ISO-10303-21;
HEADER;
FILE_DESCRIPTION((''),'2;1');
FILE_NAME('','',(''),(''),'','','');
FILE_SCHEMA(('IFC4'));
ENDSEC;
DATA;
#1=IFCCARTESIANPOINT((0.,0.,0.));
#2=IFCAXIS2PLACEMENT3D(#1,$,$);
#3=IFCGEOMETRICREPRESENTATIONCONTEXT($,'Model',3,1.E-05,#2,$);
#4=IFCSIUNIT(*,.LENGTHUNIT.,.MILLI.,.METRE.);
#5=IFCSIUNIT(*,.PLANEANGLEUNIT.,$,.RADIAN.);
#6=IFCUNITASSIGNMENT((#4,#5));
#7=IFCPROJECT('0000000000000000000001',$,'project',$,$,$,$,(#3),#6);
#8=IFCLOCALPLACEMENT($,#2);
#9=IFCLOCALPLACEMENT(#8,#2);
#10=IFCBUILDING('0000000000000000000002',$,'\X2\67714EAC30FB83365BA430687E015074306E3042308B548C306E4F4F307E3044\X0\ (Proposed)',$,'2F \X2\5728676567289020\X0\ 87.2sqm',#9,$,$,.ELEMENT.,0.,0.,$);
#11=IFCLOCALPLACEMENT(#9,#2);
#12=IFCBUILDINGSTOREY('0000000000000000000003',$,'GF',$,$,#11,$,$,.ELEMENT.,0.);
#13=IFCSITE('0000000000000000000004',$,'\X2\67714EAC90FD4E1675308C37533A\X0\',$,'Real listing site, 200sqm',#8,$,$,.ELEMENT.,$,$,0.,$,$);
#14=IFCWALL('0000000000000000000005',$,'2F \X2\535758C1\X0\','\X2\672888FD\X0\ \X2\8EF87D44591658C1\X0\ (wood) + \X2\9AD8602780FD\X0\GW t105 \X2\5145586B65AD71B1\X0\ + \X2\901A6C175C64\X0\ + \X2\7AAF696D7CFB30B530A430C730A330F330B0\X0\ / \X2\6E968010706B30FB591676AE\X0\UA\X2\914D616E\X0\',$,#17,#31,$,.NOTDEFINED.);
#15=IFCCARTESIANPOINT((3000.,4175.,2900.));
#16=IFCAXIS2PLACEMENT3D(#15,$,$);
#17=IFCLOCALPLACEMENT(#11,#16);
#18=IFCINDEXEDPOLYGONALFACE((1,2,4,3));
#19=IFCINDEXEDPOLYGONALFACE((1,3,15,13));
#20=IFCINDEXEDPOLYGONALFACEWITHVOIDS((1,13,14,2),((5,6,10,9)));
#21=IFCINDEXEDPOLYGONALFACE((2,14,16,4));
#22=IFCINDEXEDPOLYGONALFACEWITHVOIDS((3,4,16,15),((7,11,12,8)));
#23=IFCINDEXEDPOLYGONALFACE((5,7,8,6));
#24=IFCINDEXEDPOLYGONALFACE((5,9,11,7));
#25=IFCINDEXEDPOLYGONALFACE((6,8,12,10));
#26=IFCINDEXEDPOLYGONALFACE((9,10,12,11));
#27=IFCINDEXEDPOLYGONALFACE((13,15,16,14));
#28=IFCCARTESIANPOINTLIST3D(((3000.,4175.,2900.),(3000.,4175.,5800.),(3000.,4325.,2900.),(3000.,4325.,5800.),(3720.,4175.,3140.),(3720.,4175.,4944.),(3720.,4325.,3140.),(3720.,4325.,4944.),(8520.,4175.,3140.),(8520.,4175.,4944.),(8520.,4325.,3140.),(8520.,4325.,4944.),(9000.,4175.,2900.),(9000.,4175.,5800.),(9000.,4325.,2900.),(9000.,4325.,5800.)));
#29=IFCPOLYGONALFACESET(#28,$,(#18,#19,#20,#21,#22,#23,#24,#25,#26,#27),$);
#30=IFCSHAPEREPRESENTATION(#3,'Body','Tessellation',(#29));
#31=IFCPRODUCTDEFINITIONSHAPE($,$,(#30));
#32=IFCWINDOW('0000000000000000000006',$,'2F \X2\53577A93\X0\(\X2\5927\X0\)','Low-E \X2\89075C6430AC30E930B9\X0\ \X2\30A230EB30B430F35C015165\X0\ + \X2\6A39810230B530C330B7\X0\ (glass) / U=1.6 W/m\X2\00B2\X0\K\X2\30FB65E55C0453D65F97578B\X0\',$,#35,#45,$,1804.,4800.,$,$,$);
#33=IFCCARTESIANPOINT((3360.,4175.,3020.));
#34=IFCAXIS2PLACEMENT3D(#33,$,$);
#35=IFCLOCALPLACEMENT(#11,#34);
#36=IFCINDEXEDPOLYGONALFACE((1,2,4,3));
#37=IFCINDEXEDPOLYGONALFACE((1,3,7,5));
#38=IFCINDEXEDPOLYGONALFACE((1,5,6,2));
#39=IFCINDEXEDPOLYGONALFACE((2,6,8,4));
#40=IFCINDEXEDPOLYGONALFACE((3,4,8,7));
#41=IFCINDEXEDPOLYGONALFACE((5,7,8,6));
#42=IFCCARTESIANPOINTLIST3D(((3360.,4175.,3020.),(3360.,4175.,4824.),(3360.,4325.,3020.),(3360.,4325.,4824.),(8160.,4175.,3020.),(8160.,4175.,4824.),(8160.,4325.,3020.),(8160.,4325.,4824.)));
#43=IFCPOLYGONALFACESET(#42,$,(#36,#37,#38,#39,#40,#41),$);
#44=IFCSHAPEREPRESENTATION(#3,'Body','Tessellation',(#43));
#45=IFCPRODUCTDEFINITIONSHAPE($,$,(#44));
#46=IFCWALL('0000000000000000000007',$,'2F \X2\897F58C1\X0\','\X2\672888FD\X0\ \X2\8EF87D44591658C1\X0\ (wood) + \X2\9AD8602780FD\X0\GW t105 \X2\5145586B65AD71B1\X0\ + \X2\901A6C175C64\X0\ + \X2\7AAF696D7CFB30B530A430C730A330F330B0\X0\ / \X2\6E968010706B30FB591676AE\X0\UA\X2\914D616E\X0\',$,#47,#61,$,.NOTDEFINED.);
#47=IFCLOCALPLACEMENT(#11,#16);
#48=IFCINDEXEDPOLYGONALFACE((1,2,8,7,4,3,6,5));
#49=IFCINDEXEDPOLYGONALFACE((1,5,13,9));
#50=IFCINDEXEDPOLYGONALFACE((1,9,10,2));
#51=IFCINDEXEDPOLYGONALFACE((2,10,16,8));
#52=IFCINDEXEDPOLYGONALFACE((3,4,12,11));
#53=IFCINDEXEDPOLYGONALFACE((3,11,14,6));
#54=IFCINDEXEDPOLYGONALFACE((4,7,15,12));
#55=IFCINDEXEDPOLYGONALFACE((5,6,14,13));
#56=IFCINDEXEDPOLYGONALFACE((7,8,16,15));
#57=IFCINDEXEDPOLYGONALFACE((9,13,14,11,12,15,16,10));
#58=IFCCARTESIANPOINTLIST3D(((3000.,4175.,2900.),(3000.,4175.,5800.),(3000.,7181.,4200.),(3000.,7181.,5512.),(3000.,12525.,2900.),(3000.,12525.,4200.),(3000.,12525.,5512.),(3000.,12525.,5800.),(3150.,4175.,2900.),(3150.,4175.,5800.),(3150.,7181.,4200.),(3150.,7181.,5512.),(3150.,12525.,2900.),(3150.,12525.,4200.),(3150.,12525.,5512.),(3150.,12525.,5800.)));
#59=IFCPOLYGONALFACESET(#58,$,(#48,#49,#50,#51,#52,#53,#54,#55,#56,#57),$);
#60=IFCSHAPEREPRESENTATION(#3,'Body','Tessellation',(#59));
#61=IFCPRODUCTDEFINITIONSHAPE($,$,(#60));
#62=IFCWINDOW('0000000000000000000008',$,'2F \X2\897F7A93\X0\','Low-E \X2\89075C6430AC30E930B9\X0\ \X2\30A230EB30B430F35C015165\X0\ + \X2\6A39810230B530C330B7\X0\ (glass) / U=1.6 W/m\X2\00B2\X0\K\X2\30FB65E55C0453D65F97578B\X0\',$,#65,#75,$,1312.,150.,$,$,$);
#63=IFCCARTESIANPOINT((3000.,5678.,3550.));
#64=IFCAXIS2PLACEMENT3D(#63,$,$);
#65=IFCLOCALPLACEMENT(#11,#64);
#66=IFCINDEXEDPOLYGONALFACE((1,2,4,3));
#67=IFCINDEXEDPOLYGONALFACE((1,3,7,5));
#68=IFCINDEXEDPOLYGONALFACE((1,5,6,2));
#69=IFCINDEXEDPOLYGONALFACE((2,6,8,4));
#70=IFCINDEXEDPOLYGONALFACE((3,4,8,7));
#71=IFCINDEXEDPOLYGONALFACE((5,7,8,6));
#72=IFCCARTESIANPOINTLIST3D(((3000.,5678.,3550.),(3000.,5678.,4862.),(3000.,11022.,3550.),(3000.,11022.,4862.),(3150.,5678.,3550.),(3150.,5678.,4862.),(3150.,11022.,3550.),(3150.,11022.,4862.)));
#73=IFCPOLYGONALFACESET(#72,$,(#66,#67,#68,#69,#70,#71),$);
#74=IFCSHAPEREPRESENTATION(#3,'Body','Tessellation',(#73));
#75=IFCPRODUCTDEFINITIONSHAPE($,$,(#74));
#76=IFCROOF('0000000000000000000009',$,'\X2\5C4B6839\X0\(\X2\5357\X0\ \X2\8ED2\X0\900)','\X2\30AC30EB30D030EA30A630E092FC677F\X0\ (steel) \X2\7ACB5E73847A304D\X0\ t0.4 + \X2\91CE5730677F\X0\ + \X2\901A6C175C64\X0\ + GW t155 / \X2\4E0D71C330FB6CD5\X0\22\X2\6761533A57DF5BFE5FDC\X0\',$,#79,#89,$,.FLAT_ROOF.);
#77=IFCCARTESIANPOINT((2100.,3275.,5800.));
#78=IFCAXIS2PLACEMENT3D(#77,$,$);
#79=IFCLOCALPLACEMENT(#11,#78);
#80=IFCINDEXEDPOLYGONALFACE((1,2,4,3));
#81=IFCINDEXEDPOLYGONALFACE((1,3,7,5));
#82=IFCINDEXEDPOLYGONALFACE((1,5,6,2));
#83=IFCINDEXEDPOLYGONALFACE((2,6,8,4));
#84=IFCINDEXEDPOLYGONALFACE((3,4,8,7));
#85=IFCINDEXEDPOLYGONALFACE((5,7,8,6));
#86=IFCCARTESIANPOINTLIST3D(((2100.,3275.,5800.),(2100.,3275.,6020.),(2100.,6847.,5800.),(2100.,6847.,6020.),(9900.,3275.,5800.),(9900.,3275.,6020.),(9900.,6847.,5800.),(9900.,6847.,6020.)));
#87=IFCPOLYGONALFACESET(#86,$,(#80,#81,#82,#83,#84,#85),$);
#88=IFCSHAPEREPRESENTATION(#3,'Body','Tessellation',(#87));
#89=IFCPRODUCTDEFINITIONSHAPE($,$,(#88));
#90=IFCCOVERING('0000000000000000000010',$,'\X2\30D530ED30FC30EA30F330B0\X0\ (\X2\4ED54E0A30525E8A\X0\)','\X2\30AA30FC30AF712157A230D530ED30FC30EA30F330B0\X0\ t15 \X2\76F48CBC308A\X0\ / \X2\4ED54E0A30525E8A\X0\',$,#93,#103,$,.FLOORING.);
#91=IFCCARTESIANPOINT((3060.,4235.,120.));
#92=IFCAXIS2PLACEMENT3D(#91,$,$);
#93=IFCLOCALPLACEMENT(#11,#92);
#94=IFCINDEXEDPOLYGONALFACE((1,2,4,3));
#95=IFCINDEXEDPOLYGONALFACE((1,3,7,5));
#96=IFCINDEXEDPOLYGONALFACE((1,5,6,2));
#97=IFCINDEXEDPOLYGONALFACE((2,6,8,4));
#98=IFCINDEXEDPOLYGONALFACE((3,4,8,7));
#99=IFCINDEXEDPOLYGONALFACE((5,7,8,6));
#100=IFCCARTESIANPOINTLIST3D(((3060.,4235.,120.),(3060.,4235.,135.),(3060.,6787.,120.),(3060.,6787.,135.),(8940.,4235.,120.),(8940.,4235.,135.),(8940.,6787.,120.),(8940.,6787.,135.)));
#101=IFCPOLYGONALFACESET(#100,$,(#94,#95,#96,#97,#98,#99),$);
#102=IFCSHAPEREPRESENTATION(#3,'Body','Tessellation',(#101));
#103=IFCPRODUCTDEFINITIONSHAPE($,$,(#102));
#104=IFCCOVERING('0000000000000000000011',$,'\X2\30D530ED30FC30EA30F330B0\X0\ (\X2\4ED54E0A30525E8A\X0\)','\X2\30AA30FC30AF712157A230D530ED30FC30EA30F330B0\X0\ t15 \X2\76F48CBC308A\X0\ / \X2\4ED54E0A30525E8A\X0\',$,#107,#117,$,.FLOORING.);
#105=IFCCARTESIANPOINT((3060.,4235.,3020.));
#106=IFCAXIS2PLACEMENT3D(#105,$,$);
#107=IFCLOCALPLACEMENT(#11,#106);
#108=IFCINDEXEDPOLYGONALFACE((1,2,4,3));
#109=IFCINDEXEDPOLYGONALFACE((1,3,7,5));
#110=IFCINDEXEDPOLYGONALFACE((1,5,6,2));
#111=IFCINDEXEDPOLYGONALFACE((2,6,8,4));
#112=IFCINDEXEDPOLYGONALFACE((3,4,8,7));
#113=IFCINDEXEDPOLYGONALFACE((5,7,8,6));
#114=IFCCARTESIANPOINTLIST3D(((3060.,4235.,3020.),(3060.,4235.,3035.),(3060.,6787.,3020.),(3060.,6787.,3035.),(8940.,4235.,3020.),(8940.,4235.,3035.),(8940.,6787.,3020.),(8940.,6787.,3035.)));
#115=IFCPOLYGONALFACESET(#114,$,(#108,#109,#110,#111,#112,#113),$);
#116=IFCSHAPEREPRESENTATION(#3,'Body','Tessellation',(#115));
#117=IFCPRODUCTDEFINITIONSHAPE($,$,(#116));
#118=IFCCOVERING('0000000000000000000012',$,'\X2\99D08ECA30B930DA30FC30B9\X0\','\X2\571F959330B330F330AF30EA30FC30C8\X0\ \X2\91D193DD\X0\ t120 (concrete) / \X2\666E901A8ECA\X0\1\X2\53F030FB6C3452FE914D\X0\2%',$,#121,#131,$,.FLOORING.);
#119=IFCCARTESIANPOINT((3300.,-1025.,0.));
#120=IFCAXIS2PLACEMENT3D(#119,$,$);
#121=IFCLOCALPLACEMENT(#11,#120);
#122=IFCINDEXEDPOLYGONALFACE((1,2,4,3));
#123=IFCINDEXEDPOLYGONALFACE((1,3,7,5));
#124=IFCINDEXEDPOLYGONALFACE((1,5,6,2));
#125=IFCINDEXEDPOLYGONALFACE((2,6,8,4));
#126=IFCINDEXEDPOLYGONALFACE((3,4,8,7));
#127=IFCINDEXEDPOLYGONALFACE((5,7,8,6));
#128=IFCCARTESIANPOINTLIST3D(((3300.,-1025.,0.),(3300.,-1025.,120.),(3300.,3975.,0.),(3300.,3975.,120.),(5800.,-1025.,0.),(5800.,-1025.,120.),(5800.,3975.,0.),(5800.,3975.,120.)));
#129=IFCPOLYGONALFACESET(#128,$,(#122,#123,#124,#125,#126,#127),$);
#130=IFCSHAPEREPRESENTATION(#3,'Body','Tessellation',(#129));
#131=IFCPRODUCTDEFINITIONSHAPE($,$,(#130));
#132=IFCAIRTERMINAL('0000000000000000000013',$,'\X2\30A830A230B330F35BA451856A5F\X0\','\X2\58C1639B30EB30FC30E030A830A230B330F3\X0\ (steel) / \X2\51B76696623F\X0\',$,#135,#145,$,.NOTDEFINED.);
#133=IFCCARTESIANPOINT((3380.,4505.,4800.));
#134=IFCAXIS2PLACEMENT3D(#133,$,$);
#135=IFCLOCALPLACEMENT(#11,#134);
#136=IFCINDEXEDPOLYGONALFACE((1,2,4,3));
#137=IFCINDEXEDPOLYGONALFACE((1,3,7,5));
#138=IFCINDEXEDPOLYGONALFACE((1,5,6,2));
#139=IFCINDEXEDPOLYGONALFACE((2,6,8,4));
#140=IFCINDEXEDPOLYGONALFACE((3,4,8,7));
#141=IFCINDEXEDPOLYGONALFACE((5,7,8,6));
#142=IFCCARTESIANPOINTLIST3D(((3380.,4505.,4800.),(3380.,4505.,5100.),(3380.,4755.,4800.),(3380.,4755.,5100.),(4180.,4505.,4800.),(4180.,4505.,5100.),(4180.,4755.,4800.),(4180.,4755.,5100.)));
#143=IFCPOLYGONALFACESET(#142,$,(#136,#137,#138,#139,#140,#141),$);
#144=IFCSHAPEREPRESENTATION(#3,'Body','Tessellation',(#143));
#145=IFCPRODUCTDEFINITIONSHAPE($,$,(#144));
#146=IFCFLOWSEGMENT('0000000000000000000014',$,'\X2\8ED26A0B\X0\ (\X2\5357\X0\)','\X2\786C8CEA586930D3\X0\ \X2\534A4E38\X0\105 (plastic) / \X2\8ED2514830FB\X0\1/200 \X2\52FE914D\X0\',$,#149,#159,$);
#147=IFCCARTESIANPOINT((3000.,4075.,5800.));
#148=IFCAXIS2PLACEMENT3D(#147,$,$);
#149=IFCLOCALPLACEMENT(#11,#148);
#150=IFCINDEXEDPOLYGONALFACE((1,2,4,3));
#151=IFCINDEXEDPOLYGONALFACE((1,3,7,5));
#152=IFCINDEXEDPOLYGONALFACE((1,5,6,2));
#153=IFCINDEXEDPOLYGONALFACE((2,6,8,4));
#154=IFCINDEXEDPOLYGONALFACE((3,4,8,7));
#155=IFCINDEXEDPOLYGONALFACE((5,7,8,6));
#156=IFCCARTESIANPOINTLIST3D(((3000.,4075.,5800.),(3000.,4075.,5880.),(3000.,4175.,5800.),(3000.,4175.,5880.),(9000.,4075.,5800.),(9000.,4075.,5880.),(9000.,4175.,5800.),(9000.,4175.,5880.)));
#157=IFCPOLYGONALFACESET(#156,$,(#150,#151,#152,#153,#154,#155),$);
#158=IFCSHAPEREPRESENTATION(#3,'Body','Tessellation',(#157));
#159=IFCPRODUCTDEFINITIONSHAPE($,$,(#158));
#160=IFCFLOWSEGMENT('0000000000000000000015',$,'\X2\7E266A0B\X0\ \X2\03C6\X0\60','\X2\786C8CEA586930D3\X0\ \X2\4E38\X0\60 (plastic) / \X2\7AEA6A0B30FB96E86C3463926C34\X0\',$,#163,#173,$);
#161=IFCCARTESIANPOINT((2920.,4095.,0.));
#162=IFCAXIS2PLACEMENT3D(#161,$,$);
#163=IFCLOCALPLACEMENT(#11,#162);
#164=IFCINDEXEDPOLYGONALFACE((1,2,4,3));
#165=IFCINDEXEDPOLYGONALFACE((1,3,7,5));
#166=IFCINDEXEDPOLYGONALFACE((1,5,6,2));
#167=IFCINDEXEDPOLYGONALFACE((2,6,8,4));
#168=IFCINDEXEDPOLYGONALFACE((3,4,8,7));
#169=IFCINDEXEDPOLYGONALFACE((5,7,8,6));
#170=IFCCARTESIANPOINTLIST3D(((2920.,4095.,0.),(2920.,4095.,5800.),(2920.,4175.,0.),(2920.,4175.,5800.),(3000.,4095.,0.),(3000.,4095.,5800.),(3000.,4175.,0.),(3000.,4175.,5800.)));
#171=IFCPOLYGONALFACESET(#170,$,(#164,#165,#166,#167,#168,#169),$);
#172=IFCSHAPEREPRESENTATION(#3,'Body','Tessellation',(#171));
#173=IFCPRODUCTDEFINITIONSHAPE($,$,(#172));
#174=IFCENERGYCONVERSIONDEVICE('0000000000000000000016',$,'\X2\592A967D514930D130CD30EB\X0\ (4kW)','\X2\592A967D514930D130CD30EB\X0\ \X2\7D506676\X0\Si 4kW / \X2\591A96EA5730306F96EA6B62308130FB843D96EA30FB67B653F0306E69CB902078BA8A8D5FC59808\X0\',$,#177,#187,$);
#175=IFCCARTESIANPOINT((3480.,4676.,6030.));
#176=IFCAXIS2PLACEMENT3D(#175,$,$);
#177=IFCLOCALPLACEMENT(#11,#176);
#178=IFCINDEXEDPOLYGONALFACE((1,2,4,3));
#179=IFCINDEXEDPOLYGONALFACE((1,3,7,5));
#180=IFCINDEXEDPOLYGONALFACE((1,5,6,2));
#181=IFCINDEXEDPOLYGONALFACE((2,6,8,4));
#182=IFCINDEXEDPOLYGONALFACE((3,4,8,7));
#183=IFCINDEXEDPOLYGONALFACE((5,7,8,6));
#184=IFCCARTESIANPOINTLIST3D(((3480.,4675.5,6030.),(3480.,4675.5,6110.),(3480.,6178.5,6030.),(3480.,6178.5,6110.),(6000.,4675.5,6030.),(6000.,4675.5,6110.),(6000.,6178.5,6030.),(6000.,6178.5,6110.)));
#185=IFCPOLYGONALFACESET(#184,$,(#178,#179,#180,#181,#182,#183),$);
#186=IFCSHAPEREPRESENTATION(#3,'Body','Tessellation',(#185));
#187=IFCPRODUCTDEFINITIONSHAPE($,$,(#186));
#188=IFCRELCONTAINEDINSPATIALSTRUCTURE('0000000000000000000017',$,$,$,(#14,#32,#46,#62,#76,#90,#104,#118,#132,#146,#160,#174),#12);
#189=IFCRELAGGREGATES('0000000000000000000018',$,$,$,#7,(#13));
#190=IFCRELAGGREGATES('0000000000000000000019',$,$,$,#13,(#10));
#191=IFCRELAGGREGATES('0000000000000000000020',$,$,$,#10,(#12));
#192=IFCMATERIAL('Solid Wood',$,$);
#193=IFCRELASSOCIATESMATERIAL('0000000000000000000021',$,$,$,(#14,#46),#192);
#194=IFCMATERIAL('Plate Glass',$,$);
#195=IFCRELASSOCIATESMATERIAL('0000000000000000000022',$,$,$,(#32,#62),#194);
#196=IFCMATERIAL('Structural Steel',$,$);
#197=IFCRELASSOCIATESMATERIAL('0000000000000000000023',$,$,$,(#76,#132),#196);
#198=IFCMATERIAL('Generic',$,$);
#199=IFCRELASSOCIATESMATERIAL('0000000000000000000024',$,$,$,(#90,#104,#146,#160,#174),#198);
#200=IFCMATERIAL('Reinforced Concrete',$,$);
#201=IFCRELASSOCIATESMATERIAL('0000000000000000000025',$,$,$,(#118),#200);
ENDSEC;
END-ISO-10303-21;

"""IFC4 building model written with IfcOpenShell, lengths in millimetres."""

from ifc_helpers import new_model, si_unit, frame, frame_2d, origin, place, context, project, spatial, rectangle, extrude, material, element, fill, save


model = new_model("IFC4")

# Units and contexts
model_context = context("Model", 3, precision=1e-05, world=origin())
ifc_project = project(units=[si_unit("LENGTHUNIT", "METRE", prefix="MILLI"), si_unit("PLANEANGLEUNIT", "RADIAN")], contexts=[model_context])

# Site, building, storey
site_placement = place(None, origin())
site = spatial("IfcSite", under=ifc_project, at=site_placement, Name="東京都世田谷区", ObjectType="Real listing site, 200sqm", CompositionType="ELEMENT", RefElevation=0.0)
building_placement = place(site_placement, origin())
building = spatial("IfcBuilding", under=site, at=building_placement, Name="東京・茶室と縁側のある和の住まい (Proposed)", ObjectType="2F 在来木造 87.2sqm", CompositionType="ELEMENT", ElevationOfRefHeight=0.0, ElevationOfTerrain=0.0)
storey_placement = place(building_placement, origin())
storey = spatial("IfcBuildingStorey", under=building, at=storey_placement, Name="GF", CompositionType="ELEMENT", Elevation=0.0)

# Shared definitions
ifc_material_1 = material(Name="Solid Wood")

# Shared definitions
ifc_material_2 = material(Name="Reinforced Concrete")

# Shared definitions
ifc_material_3 = material(Name="Plate Glass")

# Walls, openings, windows
wall_1_placement = place(storey_placement, frame((3000.0, 4175.0, 2900.0)))
wall_1 = element("IfcWall", 1, at=wall_1_placement, inside=storey, material=ifc_material_1, Name="2F 南壁", Description="木製 軸組外壁 (wood) + 高性能GW t105 充填断熱 + 通気層 + 窯業系サイディング / 準耐火・外皮UA配慮", PredefinedType="NOTDEFINED", context=model_context, shape_type="SweptSolid", body=[
    extrude(rectangle(XDim=6000.0, YDim=150.0, at=frame_2d((3000.0, 75.0))), frame((3000.0, 4175.0, 2900.0)), (0.0, 0.0, 1.0), 2900.0),
])
opening_1_placement = place(storey_placement, frame((3360.0, 4175.0, 3020.0)))
opening_1 = element("IfcOpeningElement", 2, at=opening_1_placement, cuts=wall_1, PredefinedType="NOTDEFINED", context=model_context, shape_type="SweptSolid", body=[
    extrude(rectangle(XDim=4800.0, YDim=150.0, at=frame_2d((2400.0, 75.0))), frame((3360.0, 4175.0, 3020.0)), (0.0, 0.0, 1.0), 1804.0),
])
window_1_placement = place(storey_placement, frame((3360.0, 4175.0, 3020.0)))
window_1 = element("IfcWindow", 3, at=window_1_placement, inside=storey, material=ifc_material_3, Name="2F 南窓(大)", Description="Low-E 複層ガラス アルゴン封入 + 樹脂サッシ (glass) / U=1.6 W/m²K・日射取得型", OverallHeight=1804.0, OverallWidth=4800.0, context=model_context, shape_type="SweptSolid", body=[
    extrude(rectangle(XDim=4800.0, YDim=150.0, at=frame_2d((2400.0, 75.0))), frame((3360.0, 4175.0, 3020.0)), (0.0, 0.0, 1.0), 1804.0),
])
fill(opening_1, window_1)
wall_2_placement = place(storey_placement, frame((3000.0, 4175.0, 2900.0)))
wall_2 = element("IfcWall", 4, at=wall_2_placement, inside=storey, material=ifc_material_1, Name="2F 西壁", Description="木製 軸組外壁 (wood) + 高性能GW t105 充填断熱 + 通気層 + 窯業系サイディング / 準耐火・外皮UA配慮", PredefinedType="NOTDEFINED", context=model_context, shape_type="SweptSolid", body=[
    extrude(rectangle(XDim=150.0, YDim=8350.0, at=frame_2d((75.0, 4175.0))), frame((3000.0, 4175.0, 2900.0)), (0.0, 0.0, 1.0), 2900.0),
])
opening_2_placement = place(storey_placement, frame((3000.0, 5678.0, 3550.0)))
opening_2 = element("IfcOpeningElement", 5, at=opening_2_placement, cuts=wall_2, PredefinedType="NOTDEFINED", context=model_context, shape_type="SweptSolid", body=[
    extrude(rectangle(XDim=150.0, YDim=5344.0, at=frame_2d((75.0, 2672.0))), frame((3000.0, 5678.0, 3550.0)), (0.0, 0.0, 1.0), 1312.0),
])
window_2_placement = place(storey_placement, frame((3000.0, 5678.0, 3550.0)))
window_2 = element("IfcWindow", 6, at=window_2_placement, inside=storey, material=ifc_material_3, Name="2F 西窓", Description="Low-E 複層ガラス アルゴン封入 + 樹脂サッシ (glass) / U=1.6 W/m²K・日射取得型", OverallHeight=1312.0, OverallWidth=150.0, context=model_context, shape_type="SweptSolid", body=[
    extrude(rectangle(XDim=150.0, YDim=5344.0, at=frame_2d((75.0, 2672.0))), frame((3000.0, 5678.0, 3550.0)), (0.0, 0.0, 1.0), 1312.0),
])
fill(opening_2, window_2)

# Roof
ifc_material_4 = material(Name="Structural Steel")
for number, where, name in (
    (7, (2100.0, 3275.0, 5800.0), "屋根(南 軒900)"),
):
    element("IfcRoof", number, at=place(storey_placement, frame(where)), inside=storey, material=ifc_material_4, Name=name, Description="ガルバリウム鋼板 (steel) 立平葺き t0.4 + 野地板 + 通気層 + GW t155 / 不燃・法22条区域対応", PredefinedType="FLAT_ROOF", context=model_context, shape_type="SweptSolid", body=[
        extrude(rectangle(XDim=7800.0, YDim=3572.0, at=frame_2d((3900.0, 1786.0))), frame((2100.0, 3275.0, 5800.0)), (0.0, 0.0, 1.0), 220.0),
    ])

# Coverings
ifc_material_5 = material(Name="Generic")
covering_1_placement = place(storey_placement, frame((3060.0, 4235.0, 120.0)))
element("IfcCovering", 8, at=covering_1_placement, inside=storey, material=ifc_material_5, Name="フローリング (仕上げ床)", Description="オーク無垢フローリング t15 直貼り / 仕上げ床", PredefinedType="FLOORING", context=model_context, shape_type="SweptSolid", body=[
    extrude(rectangle(XDim=5880.0, YDim=2552.0, at=frame_2d((2940.0, 1276.0))), frame((3060.0, 4235.0, 120.0)), (0.0, 0.0, 1.0), 15.0),
])
covering_2_placement = place(storey_placement, frame((3060.0, 4235.0, 3020.0)))
element("IfcCovering", 9, at=covering_2_placement, inside=storey, material=ifc_material_5, Name="フローリング (仕上げ床)", Description="オーク無垢フローリング t15 直貼り / 仕上げ床", PredefinedType="FLOORING", context=model_context, shape_type="SweptSolid", body=[
    extrude(rectangle(XDim=5880.0, YDim=2552.0, at=frame_2d((2940.0, 1276.0))), frame((3060.0, 4235.0, 3020.0)), (0.0, 0.0, 1.0), 15.0),
])
covering_3_placement = place(storey_placement, frame((3300.0, -1025.0, 0.0)))
element("IfcCovering", 10, at=covering_3_placement, inside=storey, material=ifc_material_2, Name="駐車スペース", Description="土間コンクリート 金鏝 t120 (concrete) / 普通車1台・水勾配2%", PredefinedType="FLOORING", context=model_context, shape_type="SweptSolid", body=[
    extrude(rectangle(XDim=2500.0, YDim=5000.0, at=frame_2d((1250.0, 2500.0))), frame((3300.0, -1025.0, 0.0)), (0.0, 0.0, 1.0), 120.0),
])

# Air terminal
air_terminal_placement = place(storey_placement, frame((3380.0, 4505.0, 4800.0)))
element("IfcAirTerminal", 11, at=air_terminal_placement, inside=storey, material=ifc_material_4, Name="エアコン室内機", Description="壁掛ルームエアコン (steel) / 冷暖房", PredefinedType="NOTDEFINED", context=model_context, shape_type="SweptSolid", body=[
    extrude(rectangle(XDim=800.0, YDim=250.0, at=frame_2d((400.0, 125.0))), frame((3380.0, 4505.0, 4800.0)), (0.0, 0.0, 1.0), 300.0),
])

# Flow segments
flow_segment_1_placement = place(storey_placement, frame((3000.0, 4075.0, 5800.0)))
element("IfcFlowSegment", 12, at=flow_segment_1_placement, inside=storey, material=ifc_material_5, Name="軒樋 (南)", Description="硬質塩ビ 半丸105 (plastic) / 軒先・1/200 勾配", context=model_context, shape_type="SweptSolid", body=[
    extrude(rectangle(XDim=6000.0, YDim=100.0, at=frame_2d((3000.0, 50.0))), frame((3000.0, 4075.0, 5800.0)), (0.0, 0.0, 1.0), 80.0),
])
flow_segment_2_placement = place(storey_placement, frame((2920.0, 4095.0, 0.0)))
element("IfcFlowSegment", 13, at=flow_segment_2_placement, inside=storey, material=ifc_material_5, Name="縦樋 φ60", Description="硬質塩ビ 丸60 (plastic) / 竪樋・雨水排水", context=model_context, shape_type="SweptSolid", body=[
    extrude(rectangle(XDim=80.0, YDim=80.0, at=frame_2d((40.0, 40.0))), frame((2920.0, 4095.0, 0.0)), (0.0, 0.0, 1.0), 5800.0),
])

# Energy conversion device
energy_conversion_device_placement = place(storey_placement, frame((3480.0, 4676.0, 6030.0)))
element("IfcEnergyConversionDevice", 14, at=energy_conversion_device_placement, inside=storey, material=ifc_material_5, Name="太陽光パネル (4kW)", Description="太陽光パネル 結晶Si 4kW / 多雪地は雪止め・落雪・架台の構造確認必須", context=model_context, shape_type="SweptSolid", body=[
    extrude(rectangle(XDim=2520.0, YDim=1503.0, at=frame_2d((1260.0, 751.0))), frame((3480.0, 4676.0, 6030.0)), (0.0, 0.0, 1.0), 80.0),
])

save(model, "model.ifc")
